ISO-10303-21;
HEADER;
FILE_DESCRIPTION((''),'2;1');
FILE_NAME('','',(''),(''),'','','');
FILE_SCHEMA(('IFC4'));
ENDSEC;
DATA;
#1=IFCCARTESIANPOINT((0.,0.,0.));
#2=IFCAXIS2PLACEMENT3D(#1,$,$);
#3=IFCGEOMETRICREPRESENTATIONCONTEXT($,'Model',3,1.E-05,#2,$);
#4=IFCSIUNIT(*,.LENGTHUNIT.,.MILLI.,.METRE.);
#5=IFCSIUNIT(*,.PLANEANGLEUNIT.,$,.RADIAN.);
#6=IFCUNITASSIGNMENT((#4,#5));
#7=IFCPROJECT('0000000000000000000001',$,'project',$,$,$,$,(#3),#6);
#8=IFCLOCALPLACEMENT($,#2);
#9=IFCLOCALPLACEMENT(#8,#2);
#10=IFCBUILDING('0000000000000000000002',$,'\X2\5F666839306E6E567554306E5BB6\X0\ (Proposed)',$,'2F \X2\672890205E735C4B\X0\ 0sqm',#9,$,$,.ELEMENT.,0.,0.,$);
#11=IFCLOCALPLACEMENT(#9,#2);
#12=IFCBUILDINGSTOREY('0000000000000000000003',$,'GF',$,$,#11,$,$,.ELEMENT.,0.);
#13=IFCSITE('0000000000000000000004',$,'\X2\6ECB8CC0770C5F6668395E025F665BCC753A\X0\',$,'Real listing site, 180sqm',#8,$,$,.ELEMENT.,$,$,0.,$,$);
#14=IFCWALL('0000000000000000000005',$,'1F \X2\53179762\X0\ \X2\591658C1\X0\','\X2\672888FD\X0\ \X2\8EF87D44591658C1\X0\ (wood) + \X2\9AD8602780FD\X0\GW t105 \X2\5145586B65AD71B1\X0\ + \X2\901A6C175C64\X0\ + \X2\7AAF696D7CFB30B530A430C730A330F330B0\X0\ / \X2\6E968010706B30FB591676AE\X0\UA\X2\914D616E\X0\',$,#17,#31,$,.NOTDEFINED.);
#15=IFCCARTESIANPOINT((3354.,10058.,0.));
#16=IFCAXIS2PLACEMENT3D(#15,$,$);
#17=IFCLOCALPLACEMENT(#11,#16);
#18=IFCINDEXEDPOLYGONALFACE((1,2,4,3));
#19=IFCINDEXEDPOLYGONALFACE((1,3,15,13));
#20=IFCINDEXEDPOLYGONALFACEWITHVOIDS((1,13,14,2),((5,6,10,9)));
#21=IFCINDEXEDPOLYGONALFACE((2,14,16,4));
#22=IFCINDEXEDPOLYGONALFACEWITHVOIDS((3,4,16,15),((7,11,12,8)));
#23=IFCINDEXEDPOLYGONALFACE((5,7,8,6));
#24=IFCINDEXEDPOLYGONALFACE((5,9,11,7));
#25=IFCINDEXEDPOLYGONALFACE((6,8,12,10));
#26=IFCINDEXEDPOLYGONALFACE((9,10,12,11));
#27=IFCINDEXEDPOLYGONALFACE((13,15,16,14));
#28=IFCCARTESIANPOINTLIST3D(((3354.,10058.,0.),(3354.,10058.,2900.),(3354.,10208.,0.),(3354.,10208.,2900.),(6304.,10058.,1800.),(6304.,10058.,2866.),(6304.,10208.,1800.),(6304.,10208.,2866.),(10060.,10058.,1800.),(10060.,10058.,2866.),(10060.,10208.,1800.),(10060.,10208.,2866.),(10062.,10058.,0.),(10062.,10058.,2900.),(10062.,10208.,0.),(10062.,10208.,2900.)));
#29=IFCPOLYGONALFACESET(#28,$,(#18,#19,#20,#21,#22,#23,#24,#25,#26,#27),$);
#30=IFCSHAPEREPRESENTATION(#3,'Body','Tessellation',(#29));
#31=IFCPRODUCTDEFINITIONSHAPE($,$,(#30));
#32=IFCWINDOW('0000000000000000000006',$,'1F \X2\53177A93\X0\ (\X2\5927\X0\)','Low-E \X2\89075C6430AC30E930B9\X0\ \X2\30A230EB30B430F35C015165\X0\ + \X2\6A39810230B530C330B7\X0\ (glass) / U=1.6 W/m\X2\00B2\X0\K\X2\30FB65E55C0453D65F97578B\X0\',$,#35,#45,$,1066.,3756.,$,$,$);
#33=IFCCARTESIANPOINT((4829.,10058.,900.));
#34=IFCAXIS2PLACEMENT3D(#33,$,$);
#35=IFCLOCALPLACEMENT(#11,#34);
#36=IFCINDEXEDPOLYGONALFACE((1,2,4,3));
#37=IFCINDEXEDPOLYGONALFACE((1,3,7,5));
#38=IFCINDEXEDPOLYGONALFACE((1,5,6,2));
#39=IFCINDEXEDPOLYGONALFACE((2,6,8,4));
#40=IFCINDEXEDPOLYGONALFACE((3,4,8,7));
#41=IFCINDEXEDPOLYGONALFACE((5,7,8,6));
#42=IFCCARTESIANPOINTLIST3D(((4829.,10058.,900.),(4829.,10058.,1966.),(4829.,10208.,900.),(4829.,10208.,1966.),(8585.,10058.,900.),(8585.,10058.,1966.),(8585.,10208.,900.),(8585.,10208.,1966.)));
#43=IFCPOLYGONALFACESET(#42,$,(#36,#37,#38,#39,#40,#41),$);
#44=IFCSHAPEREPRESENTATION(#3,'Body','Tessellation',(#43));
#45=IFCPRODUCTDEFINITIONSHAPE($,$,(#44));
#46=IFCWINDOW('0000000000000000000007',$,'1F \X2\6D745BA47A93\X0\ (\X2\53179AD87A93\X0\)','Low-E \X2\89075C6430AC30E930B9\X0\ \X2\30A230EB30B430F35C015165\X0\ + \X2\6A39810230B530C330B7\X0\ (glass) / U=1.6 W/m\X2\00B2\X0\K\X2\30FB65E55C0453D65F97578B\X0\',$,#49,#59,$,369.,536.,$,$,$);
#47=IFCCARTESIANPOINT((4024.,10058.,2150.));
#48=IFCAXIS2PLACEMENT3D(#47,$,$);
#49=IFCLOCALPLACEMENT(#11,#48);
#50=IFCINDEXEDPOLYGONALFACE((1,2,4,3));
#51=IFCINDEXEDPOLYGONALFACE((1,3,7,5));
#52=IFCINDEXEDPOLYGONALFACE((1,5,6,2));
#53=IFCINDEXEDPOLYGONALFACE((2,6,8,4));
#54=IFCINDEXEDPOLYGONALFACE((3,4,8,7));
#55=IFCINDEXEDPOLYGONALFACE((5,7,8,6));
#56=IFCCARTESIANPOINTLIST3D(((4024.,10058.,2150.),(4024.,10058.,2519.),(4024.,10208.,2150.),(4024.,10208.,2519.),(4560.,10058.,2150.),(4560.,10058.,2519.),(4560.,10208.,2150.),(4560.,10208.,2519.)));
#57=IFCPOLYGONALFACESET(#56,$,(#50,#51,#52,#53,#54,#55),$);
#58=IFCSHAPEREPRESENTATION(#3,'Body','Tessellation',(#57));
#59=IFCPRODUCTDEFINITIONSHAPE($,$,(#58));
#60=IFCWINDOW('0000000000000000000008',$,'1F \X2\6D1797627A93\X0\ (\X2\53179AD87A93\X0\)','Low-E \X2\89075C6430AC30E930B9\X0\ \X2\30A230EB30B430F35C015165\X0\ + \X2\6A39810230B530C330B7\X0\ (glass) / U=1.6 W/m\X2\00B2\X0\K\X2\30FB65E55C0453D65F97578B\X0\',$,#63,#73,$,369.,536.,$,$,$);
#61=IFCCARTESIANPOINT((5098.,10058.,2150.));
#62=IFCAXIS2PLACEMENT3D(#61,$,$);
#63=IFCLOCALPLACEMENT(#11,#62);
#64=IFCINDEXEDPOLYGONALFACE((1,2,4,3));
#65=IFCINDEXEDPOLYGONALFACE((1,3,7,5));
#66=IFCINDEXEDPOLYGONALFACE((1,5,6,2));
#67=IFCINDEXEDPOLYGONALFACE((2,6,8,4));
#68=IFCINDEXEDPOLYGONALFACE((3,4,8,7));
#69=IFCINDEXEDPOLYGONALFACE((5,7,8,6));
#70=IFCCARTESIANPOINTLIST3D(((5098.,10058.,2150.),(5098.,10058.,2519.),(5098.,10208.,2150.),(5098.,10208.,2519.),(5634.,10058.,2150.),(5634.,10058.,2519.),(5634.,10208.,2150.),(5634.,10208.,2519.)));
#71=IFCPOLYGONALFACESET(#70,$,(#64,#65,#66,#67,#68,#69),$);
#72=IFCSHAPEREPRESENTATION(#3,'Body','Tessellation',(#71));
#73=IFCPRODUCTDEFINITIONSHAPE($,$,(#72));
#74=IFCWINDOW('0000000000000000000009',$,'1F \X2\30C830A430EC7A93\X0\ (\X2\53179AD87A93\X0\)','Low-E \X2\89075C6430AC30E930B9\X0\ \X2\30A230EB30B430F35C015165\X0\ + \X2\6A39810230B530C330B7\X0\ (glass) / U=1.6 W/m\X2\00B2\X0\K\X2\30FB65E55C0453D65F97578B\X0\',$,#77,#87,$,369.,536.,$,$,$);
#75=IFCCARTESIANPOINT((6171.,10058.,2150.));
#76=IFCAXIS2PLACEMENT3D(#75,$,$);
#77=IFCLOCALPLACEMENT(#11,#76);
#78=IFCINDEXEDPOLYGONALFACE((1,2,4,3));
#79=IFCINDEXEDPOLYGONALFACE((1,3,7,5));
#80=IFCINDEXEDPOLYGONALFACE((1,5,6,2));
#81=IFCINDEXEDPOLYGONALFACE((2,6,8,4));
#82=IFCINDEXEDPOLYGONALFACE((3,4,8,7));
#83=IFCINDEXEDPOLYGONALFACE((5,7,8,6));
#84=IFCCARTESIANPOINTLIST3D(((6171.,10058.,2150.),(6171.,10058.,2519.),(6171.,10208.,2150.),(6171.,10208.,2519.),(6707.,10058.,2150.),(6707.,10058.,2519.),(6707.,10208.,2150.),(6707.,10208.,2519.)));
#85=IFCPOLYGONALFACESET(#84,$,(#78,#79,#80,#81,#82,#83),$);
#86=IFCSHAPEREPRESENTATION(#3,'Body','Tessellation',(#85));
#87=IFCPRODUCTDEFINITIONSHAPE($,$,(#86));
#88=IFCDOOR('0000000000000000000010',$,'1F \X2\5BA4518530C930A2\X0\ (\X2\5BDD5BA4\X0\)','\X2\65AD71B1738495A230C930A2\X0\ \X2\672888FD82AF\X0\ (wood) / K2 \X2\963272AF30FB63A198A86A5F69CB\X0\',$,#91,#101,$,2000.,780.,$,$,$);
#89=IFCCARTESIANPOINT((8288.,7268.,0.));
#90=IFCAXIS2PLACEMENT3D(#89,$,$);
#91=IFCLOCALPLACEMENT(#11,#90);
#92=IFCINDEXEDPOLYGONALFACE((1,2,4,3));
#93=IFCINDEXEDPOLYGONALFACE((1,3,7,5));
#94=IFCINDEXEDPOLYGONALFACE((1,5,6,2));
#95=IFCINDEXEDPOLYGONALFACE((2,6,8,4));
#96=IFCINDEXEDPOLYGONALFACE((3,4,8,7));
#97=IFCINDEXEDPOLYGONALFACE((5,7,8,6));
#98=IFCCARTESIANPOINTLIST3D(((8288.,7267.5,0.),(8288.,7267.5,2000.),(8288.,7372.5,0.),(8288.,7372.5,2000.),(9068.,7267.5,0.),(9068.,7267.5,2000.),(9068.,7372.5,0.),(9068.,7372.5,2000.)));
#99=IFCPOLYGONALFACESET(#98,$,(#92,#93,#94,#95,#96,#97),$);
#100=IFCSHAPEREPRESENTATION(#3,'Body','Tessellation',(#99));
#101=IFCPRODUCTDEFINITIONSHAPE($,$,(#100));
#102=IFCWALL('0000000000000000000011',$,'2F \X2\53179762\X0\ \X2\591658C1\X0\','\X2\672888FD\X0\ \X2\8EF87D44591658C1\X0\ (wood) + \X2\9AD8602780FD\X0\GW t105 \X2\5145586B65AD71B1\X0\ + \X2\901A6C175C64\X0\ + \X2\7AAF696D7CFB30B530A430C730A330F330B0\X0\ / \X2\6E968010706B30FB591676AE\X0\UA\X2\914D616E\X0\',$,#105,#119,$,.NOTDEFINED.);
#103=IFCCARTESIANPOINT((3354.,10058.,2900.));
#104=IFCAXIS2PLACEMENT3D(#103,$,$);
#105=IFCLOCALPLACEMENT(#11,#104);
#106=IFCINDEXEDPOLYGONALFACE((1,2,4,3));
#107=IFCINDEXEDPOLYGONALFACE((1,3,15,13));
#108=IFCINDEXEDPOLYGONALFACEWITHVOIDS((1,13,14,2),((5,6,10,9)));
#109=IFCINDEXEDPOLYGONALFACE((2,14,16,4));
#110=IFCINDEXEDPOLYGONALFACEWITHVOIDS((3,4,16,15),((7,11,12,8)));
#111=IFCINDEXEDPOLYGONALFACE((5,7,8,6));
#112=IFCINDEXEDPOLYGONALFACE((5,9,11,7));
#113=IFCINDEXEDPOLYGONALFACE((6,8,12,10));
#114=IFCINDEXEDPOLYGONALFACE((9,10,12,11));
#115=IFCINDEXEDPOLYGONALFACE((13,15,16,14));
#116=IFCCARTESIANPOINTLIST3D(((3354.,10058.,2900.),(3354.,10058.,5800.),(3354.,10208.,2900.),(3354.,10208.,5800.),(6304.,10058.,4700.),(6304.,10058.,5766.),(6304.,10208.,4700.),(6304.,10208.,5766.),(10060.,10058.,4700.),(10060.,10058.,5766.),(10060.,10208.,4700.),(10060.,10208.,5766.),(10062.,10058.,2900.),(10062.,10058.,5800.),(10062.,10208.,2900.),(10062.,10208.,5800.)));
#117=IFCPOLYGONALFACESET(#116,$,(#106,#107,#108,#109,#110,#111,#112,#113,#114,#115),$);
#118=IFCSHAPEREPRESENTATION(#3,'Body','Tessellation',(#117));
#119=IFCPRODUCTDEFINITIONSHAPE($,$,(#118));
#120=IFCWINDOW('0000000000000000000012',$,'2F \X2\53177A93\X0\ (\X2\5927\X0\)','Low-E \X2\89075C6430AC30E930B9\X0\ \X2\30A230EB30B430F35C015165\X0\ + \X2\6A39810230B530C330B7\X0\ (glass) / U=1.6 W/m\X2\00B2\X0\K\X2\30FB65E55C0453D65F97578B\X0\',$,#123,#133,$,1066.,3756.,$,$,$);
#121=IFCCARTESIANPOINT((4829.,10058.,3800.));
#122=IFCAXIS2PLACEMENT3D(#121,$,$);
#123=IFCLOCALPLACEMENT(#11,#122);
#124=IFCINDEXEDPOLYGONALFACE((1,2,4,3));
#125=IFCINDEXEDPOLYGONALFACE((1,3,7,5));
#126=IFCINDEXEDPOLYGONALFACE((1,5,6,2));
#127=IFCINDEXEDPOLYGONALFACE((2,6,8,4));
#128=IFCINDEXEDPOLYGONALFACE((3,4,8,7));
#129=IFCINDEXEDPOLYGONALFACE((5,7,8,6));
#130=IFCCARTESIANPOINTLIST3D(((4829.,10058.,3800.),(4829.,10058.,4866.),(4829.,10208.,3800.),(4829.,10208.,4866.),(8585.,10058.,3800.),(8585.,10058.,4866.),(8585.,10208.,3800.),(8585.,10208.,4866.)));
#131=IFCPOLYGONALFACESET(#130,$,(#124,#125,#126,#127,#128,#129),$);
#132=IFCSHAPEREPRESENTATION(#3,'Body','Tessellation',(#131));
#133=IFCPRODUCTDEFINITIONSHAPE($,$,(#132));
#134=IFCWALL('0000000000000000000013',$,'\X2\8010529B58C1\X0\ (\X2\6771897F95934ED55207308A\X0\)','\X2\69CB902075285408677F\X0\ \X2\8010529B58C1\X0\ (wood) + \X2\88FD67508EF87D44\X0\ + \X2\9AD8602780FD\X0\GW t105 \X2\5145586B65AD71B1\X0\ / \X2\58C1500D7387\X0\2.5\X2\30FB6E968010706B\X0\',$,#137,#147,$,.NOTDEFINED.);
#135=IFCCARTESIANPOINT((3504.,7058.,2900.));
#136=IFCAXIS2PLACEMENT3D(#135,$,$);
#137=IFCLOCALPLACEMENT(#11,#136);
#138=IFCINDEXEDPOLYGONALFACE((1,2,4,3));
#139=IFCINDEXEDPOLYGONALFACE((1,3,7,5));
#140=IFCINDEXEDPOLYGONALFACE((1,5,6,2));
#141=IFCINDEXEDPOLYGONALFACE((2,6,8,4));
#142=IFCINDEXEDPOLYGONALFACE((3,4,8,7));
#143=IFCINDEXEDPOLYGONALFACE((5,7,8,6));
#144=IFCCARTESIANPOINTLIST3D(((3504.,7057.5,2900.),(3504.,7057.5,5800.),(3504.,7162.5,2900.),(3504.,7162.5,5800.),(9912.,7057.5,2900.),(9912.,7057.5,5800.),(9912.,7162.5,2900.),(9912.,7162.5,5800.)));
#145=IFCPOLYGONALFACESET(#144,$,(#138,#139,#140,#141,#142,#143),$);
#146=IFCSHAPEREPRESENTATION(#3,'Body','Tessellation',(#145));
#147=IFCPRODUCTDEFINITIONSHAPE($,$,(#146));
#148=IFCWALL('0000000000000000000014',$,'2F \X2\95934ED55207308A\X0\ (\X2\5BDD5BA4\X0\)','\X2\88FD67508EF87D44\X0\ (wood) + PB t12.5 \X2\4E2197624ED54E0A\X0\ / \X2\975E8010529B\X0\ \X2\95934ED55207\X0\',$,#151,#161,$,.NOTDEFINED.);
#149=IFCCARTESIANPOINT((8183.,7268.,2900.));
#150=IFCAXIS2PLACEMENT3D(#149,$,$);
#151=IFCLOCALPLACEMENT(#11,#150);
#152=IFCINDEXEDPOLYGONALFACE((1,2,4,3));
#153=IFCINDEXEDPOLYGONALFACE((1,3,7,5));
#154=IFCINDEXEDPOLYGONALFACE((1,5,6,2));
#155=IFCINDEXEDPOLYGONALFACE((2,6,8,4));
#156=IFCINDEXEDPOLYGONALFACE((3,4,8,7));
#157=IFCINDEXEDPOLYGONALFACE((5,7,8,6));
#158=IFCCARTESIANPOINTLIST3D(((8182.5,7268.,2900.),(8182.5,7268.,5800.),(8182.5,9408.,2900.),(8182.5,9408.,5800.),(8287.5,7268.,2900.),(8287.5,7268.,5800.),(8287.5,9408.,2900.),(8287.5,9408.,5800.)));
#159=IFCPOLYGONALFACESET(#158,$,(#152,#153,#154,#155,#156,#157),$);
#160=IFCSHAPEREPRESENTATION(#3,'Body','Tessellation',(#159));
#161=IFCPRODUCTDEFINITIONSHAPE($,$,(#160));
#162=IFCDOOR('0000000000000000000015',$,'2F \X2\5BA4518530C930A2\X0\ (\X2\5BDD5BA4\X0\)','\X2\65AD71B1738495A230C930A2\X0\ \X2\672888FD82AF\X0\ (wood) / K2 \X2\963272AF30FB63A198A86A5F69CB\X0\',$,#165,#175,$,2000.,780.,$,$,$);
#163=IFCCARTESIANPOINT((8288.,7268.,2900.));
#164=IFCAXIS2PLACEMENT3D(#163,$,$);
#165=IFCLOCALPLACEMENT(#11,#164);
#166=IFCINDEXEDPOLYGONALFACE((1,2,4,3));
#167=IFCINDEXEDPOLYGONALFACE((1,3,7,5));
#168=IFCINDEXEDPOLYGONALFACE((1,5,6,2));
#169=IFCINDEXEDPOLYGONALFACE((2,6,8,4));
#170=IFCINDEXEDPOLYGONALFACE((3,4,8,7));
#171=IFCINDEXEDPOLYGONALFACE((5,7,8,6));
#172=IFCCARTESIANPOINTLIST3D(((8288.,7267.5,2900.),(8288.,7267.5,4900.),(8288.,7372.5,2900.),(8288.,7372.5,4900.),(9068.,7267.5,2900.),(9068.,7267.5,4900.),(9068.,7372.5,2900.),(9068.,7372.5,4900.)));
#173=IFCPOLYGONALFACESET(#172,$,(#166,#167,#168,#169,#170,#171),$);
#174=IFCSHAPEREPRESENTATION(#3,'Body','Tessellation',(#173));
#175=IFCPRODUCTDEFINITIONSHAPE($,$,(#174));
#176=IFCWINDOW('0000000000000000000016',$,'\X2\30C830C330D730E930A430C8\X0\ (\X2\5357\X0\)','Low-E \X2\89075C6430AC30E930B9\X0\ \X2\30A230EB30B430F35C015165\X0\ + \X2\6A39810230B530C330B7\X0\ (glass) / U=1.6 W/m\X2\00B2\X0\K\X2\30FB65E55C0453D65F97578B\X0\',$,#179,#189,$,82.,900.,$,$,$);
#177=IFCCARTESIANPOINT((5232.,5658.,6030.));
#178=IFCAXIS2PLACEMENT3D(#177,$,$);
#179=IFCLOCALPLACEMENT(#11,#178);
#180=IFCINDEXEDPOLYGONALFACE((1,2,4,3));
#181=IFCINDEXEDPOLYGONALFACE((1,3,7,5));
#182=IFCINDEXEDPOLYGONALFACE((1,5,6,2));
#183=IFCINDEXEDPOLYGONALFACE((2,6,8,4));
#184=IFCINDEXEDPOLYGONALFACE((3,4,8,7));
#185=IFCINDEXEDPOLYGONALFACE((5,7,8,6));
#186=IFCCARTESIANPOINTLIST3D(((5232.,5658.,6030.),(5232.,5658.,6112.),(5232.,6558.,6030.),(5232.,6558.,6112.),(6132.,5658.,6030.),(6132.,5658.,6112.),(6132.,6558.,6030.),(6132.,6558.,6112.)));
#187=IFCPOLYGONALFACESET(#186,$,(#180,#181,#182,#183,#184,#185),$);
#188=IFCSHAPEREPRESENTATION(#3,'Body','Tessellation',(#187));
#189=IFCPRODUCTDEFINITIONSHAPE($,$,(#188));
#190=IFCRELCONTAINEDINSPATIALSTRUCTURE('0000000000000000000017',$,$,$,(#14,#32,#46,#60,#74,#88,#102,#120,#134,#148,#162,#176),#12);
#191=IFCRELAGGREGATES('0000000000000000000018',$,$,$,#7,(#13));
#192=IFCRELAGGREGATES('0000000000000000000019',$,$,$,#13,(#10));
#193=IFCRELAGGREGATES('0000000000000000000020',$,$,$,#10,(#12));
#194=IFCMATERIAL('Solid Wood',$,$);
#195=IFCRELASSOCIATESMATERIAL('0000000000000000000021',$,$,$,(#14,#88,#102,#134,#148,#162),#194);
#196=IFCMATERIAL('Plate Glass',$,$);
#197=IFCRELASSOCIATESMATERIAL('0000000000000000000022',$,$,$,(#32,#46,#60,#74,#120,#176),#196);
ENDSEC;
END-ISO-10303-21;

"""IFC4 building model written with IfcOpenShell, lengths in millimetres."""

from ifc_helpers import new_model, si_unit, frame, frame_2d, origin, place, context, project, spatial, rectangle, extrude, material, element, fill, save


model = new_model("IFC4")

# Units and contexts
model_context = context("Model", 3, precision=1e-05, world=origin())
ifc_project = project(units=[si_unit("LENGTHUNIT", "METRE", prefix="MILLI"), si_unit("PLANEANGLEUNIT", "RADIAN")], contexts=[model_context])

# Site, building, storey
site_placement = place(None, origin())
site = spatial("IfcSite", under=ifc_project, at=site_placement, Name="滋賀県彦根市彦富町", ObjectType="Real listing site, 180sqm", CompositionType="ELEMENT", RefElevation=0.0)
building_placement = place(site_placement, origin())
building = spatial("IfcBuilding", under=site, at=building_placement, Name="彦根の湖畔の家 (Proposed)", ObjectType="2F 木造平屋 0sqm", CompositionType="ELEMENT", ElevationOfRefHeight=0.0, ElevationOfTerrain=0.0)
storey_placement = place(building_placement, origin())
storey = spatial("IfcBuildingStorey", under=building, at=storey_placement, Name="GF", CompositionType="ELEMENT", Elevation=0.0)

# Wall, openings, windows
ifc_material_1 = material(Name="Solid Wood")
wall_1_placement = place(storey_placement, frame((3354.0, 10058.0, 0.0)))
wall_1 = element("IfcWall", 1, at=wall_1_placement, inside=storey, material=ifc_material_1, Name="1F 北面 外壁", Description="木製 軸組外壁 (wood) + 高性能GW t105 充填断熱 + 通気層 + 窯業系サイディング / 準耐火・外皮UA配慮", PredefinedType="NOTDEFINED", context=model_context, shape_type="SweptSolid", body=[
    extrude(rectangle(XDim=6708.0, YDim=150.0, at=frame_2d((3354.0, 75.0))), frame((3354.0, 10058.0, 0.0)), (0.0, 0.0, 1.0), 2900.0),
])
opening_1_placement = place(storey_placement, frame((4829.0, 10058.0, 900.0)))
opening_1 = element("IfcOpeningElement", 2, at=opening_1_placement, cuts=wall_1, PredefinedType="NOTDEFINED", context=model_context, shape_type="SweptSolid", body=[
    extrude(rectangle(XDim=3756.0, YDim=150.0, at=frame_2d((1878.0, 75.0))), frame((4829.0, 10058.0, 900.0)), (0.0, 0.0, 1.0), 1066.0),
])
opening_2_placement = place(storey_placement, frame((4024.0, 10058.0, 2150.0)))
opening_2 = element("IfcOpeningElement", 3, at=opening_2_placement, cuts=wall_1, PredefinedType="NOTDEFINED", context=model_context, shape_type="SweptSolid", body=[
    extrude(rectangle(XDim=536.0, YDim=150.0, at=frame_2d((268.0, 75.0))), frame((4024.0, 10058.0, 2150.0)), (0.0, 0.0, 1.0), 369.0),
])
opening_3_placement = place(storey_placement, frame((5098.0, 10058.0, 2150.0)))
opening_3 = element("IfcOpeningElement", 4, at=opening_3_placement, cuts=wall_1, PredefinedType="NOTDEFINED", context=model_context, shape_type="SweptSolid", body=[
    extrude(rectangle(XDim=536.0, YDim=150.0, at=frame_2d((268.0, 75.0))), frame((5098.0, 10058.0, 2150.0)), (0.0, 0.0, 1.0), 369.0),
])
opening_4_placement = place(storey_placement, frame((6171.0, 10058.0, 2150.0)))
opening_4 = element("IfcOpeningElement", 5, at=opening_4_placement, cuts=wall_1, PredefinedType="NOTDEFINED", context=model_context, shape_type="SweptSolid", body=[
    extrude(rectangle(XDim=536.0, YDim=150.0, at=frame_2d((268.0, 75.0))), frame((6171.0, 10058.0, 2150.0)), (0.0, 0.0, 1.0), 369.0),
])
ifc_material_2 = material(Name="Plate Glass")
window_1_placement = place(storey_placement, frame((4829.0, 10058.0, 900.0)))
window_1 = element("IfcWindow", 6, at=window_1_placement, inside=storey, material=ifc_material_2, Name="1F 北窓 (大)", Description="Low-E 複層ガラス アルゴン封入 + 樹脂サッシ (glass) / U=1.6 W/m²K・日射取得型", OverallHeight=1066.0, OverallWidth=3756.0, context=model_context, shape_type="SweptSolid", body=[
    extrude(rectangle(XDim=3756.0, YDim=150.0, at=frame_2d((1878.0, 75.0))), frame((4829.0, 10058.0, 900.0)), (0.0, 0.0, 1.0), 1066.0),
])
fill(opening_1, window_1)
window_2_placement = place(storey_placement, frame((4024.0, 10058.0, 2150.0)))
window_2 = element("IfcWindow", 7, at=window_2_placement, inside=storey, material=ifc_material_2, Name="1F 浴室窓 (北高窓)", Description="Low-E 複層ガラス アルゴン封入 + 樹脂サッシ (glass) / U=1.6 W/m²K・日射取得型", OverallHeight=369.0, OverallWidth=536.0, context=model_context, shape_type="SweptSolid", body=[
    extrude(rectangle(XDim=536.0, YDim=150.0, at=frame_2d((268.0, 75.0))), frame((4024.0, 10058.0, 2150.0)), (0.0, 0.0, 1.0), 369.0),
])
fill(opening_2, window_2)
window_3_placement = place(storey_placement, frame((5098.0, 10058.0, 2150.0)))
window_3 = element("IfcWindow", 8, at=window_3_placement, inside=storey, material=ifc_material_2, Name="1F 洗面窓 (北高窓)", Description="Low-E 複層ガラス アルゴン封入 + 樹脂サッシ (glass) / U=1.6 W/m²K・日射取得型", OverallHeight=369.0, OverallWidth=536.0, context=model_context, shape_type="SweptSolid", body=[
    extrude(rectangle(XDim=536.0, YDim=150.0, at=frame_2d((268.0, 75.0))), frame((5098.0, 10058.0, 2150.0)), (0.0, 0.0, 1.0), 369.0),
])
fill(opening_3, window_3)
window_4_placement = place(storey_placement, frame((6171.0, 10058.0, 2150.0)))
window_4 = element("IfcWindow", 9, at=window_4_placement, inside=storey, material=ifc_material_2, Name="1F トイレ窓 (北高窓)", Description="Low-E 複層ガラス アルゴン封入 + 樹脂サッシ (glass) / U=1.6 W/m²K・日射取得型", OverallHeight=369.0, OverallWidth=536.0, context=model_context, shape_type="SweptSolid", body=[
    extrude(rectangle(XDim=536.0, YDim=150.0, at=frame_2d((268.0, 75.0))), frame((6171.0, 10058.0, 2150.0)), (0.0, 0.0, 1.0), 369.0),
])
fill(opening_4, window_4)

# Door
door_1_placement = place(storey_placement, frame((8288.0, 7268.0, 0.0)))
element("IfcDoor", 10, at=door_1_placement, inside=storey, material=ifc_material_1, Name="1F 室内ドア (寝室)", Description="断熱玄関ドア 木製芯 (wood) / K2 防犯・採風機構", OverallHeight=2000.0, OverallWidth=780.0, context=model_context, shape_type="SweptSolid", body=[
    extrude(rectangle(XDim=780.0, YDim=105.0, at=frame_2d((390.0, 52.0))), frame((8288.0, 7268.0, 0.0)), (0.0, 0.0, 1.0), 2000.0),
])

# Wall, opening, window
wall_2_placement = place(storey_placement, frame((3354.0, 10058.0, 2900.0)))
wall_2 = element("IfcWall", 11, at=wall_2_placement, inside=storey, material=ifc_material_1, Name="2F 北面 外壁", Description="木製 軸組外壁 (wood) + 高性能GW t105 充填断熱 + 通気層 + 窯業系サイディング / 準耐火・外皮UA配慮", PredefinedType="NOTDEFINED", context=model_context, shape_type="SweptSolid", body=[
    extrude(rectangle(XDim=6708.0, YDim=150.0, at=frame_2d((3354.0, 75.0))), frame((3354.0, 10058.0, 2900.0)), (0.0, 0.0, 1.0), 2900.0),
])
opening_5_placement = place(storey_placement, frame((4829.0, 10058.0, 3800.0)))
opening_5 = element("IfcOpeningElement", 12, at=opening_5_placement, cuts=wall_2, PredefinedType="NOTDEFINED", context=model_context, shape_type="SweptSolid", body=[
    extrude(rectangle(XDim=3756.0, YDim=150.0, at=frame_2d((1878.0, 75.0))), frame((4829.0, 10058.0, 3800.0)), (0.0, 0.0, 1.0), 1066.0),
])
window_5_placement = place(storey_placement, frame((4829.0, 10058.0, 3800.0)))
window_5 = element("IfcWindow", 13, at=window_5_placement, inside=storey, material=ifc_material_2, Name="2F 北窓 (大)", Description="Low-E 複層ガラス アルゴン封入 + 樹脂サッシ (glass) / U=1.6 W/m²K・日射取得型", OverallHeight=1066.0, OverallWidth=3756.0, context=model_context, shape_type="SweptSolid", body=[
    extrude(rectangle(XDim=3756.0, YDim=150.0, at=frame_2d((1878.0, 75.0))), frame((4829.0, 10058.0, 3800.0)), (0.0, 0.0, 1.0), 1066.0),
])
fill(opening_5, window_5)

# Walls
wall_3_placement = place(storey_placement, frame((3504.0, 7058.0, 2900.0)))
element("IfcWall", 14, at=wall_3_placement, inside=storey, material=ifc_material_1, Name="耐力壁 (東西間仕切り)", Description="構造用合板 耐力壁 (wood) + 製材軸組 + 高性能GW t105 充填断熱 / 壁倍率2.5・準耐火", PredefinedType="NOTDEFINED", context=model_context, shape_type="SweptSolid", body=[
    extrude(rectangle(XDim=6408.0, YDim=105.0, at=frame_2d((3204.0, 52.0))), frame((3504.0, 7058.0, 2900.0)), (0.0, 0.0, 1.0), 2900.0),
])
wall_4_placement = place(storey_placement, frame((8183.0, 7268.0, 2900.0)))
element("IfcWall", 15, at=wall_4_placement, inside=storey, material=ifc_material_1, Name="2F 間仕切り (寝室)", Description="製材軸組 (wood) + PB t12.5 両面仕上 / 非耐力 間仕切", PredefinedType="NOTDEFINED", context=model_context, shape_type="SweptSolid", body=[
    extrude(rectangle(XDim=105.0, YDim=2140.0, at=frame_2d((52.0, 1070.0))), frame((8183.0, 7268.0, 2900.0)), (0.0, 0.0, 1.0), 2900.0),
])

# Door
door_2_placement = place(storey_placement, frame((8288.0, 7268.0, 2900.0)))
element("IfcDoor", 16, at=door_2_placement, inside=storey, material=ifc_material_1, Name="2F 室内ドア (寝室)", Description="断熱玄関ドア 木製芯 (wood) / K2 防犯・採風機構", OverallHeight=2000.0, OverallWidth=780.0, context=model_context, shape_type="SweptSolid", body=[
    extrude(rectangle(XDim=780.0, YDim=105.0, at=frame_2d((390.0, 52.0))), frame((8288.0, 7268.0, 2900.0)), (0.0, 0.0, 1.0), 2000.0),
])

# Window
window_6_placement = place(storey_placement, frame((5232.0, 5658.0, 6030.0)))
element("IfcWindow", 17, at=window_6_placement, inside=storey, material=ifc_material_2, Name="トップライト (南)", Description="Low-E 複層ガラス アルゴン封入 + 樹脂サッシ (glass) / U=1.6 W/m²K・日射取得型", OverallHeight=82.0, OverallWidth=900.0, context=model_context, shape_type="SweptSolid", body=[
    extrude(rectangle(XDim=900.0, YDim=900.0, at=frame_2d((450.0, 450.0))), frame((5232.0, 5658.0, 6030.0)), (0.0, 0.0, 1.0), 82.0),
])

save(model, "model.ifc")
